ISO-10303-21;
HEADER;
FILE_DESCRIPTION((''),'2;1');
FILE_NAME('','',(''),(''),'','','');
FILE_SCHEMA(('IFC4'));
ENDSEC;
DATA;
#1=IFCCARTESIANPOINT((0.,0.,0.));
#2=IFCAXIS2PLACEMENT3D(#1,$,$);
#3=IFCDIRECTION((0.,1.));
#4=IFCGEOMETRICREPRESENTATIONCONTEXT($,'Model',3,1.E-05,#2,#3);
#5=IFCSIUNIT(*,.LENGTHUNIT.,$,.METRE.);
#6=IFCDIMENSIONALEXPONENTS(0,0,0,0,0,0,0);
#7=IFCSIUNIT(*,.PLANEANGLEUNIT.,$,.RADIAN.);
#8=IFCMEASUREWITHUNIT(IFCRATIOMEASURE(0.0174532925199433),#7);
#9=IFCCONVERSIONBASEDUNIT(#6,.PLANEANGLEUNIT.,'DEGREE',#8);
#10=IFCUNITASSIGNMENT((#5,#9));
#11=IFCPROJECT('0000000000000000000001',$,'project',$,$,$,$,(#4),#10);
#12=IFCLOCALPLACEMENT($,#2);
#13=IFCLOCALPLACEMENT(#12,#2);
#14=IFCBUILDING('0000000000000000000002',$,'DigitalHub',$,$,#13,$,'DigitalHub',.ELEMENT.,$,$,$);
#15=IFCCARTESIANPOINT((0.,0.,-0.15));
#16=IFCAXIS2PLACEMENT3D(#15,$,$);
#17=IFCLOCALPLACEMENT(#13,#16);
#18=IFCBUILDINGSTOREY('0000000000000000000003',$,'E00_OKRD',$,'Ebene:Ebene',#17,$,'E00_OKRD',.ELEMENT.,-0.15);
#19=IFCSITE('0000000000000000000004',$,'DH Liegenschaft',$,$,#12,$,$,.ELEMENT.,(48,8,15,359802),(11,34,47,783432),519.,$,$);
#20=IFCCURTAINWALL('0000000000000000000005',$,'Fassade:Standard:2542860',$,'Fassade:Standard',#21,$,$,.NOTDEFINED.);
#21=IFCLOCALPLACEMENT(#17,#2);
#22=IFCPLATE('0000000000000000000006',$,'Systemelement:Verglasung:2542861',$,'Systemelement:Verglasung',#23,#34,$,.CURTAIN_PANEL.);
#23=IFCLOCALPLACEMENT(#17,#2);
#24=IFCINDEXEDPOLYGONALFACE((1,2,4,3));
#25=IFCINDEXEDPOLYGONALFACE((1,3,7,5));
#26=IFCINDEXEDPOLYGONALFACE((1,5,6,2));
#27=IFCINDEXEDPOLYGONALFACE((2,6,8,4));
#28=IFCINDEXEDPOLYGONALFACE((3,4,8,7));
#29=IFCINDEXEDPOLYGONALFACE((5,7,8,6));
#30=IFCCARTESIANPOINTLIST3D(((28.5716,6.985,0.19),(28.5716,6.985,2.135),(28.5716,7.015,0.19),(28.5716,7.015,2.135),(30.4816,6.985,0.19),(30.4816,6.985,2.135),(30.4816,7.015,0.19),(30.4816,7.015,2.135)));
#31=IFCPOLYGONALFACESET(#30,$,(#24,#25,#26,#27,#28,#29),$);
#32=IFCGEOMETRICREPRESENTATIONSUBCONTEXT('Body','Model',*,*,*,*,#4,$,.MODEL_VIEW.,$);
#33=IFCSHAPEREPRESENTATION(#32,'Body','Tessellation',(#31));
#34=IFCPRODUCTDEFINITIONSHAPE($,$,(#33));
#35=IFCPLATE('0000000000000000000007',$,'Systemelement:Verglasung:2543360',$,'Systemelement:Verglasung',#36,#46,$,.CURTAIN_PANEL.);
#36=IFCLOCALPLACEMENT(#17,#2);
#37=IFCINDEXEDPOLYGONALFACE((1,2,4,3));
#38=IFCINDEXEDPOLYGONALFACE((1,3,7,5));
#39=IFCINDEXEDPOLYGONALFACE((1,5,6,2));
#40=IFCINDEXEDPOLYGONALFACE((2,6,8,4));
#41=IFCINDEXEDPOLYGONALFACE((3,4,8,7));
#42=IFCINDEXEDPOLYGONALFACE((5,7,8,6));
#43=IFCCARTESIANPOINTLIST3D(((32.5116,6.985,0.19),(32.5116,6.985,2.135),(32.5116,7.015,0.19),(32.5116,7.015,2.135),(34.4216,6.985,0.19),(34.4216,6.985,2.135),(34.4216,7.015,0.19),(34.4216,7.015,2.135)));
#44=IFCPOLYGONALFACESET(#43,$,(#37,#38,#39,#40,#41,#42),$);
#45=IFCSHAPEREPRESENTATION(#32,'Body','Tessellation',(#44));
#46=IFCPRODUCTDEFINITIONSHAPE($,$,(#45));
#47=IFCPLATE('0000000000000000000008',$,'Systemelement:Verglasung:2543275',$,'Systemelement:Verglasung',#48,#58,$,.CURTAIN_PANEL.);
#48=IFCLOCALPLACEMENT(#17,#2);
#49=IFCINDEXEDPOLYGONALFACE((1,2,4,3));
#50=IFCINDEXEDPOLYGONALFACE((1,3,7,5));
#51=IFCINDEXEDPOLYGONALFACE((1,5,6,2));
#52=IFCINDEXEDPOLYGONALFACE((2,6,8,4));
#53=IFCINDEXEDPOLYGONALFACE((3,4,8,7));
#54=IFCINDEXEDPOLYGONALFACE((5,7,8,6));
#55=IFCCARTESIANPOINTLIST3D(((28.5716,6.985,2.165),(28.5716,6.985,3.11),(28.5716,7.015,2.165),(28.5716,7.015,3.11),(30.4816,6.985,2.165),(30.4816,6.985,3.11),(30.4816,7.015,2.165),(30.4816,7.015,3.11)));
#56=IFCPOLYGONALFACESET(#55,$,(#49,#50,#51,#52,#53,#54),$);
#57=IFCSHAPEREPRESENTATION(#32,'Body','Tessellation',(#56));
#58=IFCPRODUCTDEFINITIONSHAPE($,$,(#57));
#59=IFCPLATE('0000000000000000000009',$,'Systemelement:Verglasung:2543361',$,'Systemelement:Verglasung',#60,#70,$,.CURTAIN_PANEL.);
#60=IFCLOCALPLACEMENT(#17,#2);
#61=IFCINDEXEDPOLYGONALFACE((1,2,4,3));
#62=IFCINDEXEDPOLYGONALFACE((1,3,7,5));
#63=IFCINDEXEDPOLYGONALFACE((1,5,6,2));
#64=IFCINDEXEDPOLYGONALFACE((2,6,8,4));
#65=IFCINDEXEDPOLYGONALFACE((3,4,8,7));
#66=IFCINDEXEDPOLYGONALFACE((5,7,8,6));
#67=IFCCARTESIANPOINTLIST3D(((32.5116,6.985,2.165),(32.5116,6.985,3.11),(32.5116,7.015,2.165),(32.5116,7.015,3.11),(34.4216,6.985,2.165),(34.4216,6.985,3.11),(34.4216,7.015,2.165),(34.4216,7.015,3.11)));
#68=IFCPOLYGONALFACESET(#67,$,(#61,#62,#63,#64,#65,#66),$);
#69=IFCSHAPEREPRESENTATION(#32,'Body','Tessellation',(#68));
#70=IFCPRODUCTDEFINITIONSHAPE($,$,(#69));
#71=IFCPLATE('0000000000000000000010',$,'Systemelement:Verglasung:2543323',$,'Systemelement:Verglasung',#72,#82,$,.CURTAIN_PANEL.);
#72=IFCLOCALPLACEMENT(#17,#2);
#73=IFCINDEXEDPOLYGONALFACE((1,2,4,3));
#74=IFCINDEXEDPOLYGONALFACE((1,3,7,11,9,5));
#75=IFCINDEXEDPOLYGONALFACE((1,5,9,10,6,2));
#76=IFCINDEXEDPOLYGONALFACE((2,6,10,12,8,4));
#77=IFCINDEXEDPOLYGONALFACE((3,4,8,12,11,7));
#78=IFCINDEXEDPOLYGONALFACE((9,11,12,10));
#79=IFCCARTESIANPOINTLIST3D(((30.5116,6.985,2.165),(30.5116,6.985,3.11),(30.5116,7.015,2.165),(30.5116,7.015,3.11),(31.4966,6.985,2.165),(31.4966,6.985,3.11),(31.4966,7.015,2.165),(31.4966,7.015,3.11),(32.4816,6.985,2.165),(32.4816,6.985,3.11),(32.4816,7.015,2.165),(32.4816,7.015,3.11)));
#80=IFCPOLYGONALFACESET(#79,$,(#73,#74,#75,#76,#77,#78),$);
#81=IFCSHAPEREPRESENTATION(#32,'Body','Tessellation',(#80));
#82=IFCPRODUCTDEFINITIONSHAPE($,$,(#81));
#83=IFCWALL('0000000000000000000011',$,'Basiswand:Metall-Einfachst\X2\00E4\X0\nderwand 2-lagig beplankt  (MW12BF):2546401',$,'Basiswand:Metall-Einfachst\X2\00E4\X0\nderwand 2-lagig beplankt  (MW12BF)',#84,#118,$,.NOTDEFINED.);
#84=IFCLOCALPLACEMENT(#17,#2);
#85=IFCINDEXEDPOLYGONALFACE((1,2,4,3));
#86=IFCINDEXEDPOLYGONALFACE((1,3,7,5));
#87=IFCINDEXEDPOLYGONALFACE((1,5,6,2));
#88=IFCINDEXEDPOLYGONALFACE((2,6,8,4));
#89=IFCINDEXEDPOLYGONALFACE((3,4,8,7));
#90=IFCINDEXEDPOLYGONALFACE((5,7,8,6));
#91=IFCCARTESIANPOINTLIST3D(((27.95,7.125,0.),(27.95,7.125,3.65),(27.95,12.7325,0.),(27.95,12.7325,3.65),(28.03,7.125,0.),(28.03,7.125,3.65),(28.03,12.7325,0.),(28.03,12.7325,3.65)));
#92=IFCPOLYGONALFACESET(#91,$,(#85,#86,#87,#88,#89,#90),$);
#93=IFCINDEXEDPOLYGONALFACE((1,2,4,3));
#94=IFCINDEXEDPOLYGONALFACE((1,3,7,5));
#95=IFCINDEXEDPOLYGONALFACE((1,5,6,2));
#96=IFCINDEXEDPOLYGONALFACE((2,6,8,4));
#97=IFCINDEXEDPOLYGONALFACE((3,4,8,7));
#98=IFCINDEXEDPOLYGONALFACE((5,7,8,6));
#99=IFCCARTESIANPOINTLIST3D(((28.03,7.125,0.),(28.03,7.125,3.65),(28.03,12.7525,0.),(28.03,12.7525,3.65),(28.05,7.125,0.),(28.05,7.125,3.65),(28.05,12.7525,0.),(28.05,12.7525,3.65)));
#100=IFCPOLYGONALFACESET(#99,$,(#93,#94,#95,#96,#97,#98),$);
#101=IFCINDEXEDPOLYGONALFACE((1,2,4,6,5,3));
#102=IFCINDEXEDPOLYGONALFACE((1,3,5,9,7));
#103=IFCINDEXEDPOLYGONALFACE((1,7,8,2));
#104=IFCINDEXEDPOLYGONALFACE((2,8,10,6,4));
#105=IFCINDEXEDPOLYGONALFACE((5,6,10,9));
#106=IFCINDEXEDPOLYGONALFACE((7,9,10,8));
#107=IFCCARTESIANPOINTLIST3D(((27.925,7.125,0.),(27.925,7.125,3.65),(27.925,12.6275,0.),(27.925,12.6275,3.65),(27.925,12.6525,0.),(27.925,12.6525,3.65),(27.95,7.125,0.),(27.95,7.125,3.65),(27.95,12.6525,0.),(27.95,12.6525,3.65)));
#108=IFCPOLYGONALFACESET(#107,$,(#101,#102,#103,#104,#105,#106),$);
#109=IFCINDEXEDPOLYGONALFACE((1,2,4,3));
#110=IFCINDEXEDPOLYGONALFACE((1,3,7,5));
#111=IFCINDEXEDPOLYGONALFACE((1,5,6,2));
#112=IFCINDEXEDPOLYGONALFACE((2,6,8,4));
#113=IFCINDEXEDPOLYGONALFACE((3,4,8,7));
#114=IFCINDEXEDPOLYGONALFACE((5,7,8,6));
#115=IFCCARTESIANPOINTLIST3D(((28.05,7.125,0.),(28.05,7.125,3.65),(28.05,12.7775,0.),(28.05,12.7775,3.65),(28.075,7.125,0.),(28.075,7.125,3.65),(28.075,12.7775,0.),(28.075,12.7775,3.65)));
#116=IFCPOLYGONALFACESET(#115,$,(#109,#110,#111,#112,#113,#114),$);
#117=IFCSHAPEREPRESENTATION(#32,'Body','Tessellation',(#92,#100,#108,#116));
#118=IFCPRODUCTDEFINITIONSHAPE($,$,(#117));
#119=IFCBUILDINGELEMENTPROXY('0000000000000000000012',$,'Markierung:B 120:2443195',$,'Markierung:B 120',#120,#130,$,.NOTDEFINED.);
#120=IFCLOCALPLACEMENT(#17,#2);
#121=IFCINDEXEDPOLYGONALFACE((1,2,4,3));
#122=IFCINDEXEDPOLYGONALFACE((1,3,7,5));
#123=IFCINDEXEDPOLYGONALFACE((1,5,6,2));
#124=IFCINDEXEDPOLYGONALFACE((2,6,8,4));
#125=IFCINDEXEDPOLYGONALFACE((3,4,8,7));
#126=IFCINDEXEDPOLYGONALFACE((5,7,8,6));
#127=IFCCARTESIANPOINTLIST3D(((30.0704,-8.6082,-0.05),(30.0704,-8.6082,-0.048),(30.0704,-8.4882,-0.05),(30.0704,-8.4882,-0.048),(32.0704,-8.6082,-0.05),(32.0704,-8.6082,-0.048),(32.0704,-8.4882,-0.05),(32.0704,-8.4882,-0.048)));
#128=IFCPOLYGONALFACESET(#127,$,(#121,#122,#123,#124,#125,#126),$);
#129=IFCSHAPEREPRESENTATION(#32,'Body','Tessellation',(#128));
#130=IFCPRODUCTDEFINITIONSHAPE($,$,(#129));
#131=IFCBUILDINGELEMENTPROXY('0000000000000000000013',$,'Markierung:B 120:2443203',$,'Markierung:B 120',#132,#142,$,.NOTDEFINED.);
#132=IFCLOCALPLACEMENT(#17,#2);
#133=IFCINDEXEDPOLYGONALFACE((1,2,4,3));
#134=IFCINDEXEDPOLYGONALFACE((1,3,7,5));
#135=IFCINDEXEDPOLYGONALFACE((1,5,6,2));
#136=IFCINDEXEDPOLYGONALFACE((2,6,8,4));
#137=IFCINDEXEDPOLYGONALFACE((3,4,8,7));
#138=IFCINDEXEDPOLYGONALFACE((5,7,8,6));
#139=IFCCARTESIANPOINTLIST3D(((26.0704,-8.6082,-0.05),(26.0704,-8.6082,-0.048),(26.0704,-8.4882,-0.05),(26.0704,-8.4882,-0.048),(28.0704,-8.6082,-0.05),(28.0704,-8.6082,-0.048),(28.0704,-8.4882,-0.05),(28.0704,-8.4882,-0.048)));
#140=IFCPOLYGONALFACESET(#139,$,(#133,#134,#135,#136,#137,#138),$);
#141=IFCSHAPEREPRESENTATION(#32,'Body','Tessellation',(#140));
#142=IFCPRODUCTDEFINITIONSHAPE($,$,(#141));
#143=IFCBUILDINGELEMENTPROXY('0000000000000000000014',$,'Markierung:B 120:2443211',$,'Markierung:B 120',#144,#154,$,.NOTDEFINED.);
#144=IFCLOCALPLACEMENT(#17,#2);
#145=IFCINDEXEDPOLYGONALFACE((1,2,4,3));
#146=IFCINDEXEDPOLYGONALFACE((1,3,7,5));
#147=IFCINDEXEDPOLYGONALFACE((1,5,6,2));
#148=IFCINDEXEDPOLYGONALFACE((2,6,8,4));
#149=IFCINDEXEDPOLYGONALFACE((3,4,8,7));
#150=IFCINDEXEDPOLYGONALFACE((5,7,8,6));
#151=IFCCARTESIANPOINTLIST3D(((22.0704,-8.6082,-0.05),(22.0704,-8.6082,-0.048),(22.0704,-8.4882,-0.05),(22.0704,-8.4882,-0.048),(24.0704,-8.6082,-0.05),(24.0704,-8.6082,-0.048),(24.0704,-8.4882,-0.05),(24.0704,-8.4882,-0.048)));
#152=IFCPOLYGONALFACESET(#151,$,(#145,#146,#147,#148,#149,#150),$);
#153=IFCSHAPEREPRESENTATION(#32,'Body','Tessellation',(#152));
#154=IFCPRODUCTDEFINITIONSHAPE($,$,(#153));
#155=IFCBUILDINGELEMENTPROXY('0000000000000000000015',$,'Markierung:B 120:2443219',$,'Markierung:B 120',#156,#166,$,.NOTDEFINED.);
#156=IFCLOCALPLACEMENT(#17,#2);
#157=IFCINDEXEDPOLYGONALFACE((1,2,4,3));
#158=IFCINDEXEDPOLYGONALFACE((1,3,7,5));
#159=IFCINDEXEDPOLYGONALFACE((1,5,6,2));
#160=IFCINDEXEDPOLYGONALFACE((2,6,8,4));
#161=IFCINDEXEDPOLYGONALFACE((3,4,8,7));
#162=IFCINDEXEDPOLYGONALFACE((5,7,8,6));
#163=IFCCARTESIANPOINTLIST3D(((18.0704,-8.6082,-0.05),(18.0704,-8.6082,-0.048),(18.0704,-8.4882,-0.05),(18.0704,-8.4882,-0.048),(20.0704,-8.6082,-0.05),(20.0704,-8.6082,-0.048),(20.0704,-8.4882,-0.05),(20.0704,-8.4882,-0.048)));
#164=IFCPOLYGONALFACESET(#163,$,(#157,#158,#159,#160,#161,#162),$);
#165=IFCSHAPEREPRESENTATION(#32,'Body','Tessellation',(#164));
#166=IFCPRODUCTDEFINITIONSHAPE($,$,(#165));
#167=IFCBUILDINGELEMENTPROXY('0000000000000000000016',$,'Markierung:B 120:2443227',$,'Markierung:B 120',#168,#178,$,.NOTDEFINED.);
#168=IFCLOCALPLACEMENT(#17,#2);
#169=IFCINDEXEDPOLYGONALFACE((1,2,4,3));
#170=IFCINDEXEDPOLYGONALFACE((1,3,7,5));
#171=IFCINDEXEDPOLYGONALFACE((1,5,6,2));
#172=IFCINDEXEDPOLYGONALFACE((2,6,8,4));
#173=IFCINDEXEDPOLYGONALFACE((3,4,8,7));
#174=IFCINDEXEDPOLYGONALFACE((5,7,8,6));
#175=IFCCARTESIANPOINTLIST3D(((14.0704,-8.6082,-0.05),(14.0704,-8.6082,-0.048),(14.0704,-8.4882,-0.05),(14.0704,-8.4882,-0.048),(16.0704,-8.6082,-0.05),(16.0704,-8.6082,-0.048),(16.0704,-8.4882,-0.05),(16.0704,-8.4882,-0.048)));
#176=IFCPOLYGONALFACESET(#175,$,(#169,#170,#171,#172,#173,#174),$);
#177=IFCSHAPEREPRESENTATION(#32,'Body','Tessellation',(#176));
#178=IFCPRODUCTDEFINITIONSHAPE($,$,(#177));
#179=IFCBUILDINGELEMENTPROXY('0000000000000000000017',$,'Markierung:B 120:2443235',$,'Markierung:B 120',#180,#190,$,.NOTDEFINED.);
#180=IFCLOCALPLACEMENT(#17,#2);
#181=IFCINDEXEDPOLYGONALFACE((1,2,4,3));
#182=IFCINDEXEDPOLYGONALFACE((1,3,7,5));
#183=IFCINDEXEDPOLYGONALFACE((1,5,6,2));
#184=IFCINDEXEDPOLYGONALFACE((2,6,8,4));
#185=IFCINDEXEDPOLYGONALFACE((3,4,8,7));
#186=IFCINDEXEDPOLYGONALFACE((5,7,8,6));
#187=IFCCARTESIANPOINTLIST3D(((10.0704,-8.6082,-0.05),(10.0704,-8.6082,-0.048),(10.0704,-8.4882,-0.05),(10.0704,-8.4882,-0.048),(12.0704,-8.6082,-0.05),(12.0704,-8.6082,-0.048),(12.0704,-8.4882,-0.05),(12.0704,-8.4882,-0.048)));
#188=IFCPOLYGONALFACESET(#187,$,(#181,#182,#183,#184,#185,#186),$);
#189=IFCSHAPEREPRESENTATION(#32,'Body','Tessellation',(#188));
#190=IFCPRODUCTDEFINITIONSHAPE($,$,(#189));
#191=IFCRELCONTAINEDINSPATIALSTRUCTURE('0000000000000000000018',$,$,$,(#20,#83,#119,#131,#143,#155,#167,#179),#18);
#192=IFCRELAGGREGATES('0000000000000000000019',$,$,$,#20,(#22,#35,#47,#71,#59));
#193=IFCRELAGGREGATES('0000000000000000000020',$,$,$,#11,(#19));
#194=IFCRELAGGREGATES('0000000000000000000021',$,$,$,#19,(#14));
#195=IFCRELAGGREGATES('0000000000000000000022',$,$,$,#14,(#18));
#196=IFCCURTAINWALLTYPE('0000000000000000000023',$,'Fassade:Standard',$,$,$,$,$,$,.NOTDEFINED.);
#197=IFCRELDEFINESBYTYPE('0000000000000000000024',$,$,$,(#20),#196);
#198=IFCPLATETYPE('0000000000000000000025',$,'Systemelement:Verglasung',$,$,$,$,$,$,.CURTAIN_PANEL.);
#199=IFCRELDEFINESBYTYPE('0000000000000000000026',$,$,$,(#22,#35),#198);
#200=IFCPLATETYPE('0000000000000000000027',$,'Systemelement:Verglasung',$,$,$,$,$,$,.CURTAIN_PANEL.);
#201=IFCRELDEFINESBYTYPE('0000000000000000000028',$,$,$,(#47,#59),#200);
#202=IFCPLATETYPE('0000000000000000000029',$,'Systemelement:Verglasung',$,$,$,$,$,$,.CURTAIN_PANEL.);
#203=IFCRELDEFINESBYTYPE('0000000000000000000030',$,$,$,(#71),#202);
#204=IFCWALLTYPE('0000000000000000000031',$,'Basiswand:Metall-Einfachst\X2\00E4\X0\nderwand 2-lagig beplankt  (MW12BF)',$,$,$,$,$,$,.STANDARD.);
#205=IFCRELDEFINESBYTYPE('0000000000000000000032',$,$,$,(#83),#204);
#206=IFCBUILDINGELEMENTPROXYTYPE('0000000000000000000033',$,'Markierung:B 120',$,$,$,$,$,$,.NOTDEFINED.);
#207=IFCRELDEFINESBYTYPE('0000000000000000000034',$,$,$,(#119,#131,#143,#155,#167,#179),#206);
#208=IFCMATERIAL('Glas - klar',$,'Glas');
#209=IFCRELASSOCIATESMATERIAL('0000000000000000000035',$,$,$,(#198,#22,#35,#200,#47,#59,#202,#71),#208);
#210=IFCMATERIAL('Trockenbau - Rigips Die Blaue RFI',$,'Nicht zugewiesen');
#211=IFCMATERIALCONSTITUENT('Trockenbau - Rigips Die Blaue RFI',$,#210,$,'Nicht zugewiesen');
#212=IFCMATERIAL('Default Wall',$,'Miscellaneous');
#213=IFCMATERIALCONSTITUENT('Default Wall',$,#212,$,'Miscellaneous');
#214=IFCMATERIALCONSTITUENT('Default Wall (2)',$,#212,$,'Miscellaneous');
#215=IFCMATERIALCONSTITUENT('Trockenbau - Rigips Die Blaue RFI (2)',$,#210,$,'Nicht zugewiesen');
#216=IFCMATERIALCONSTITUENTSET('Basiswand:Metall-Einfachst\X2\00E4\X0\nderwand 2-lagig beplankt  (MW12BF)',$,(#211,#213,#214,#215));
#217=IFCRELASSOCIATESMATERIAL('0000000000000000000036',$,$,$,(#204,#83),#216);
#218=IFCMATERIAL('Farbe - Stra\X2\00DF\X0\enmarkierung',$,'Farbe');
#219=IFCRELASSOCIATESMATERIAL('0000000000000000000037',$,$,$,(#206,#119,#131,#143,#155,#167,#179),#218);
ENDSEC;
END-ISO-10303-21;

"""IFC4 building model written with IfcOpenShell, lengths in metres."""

from ifc_helpers import new_model, entity, si_unit, converted_unit, direction, frame, origin, place, context, subcontext, project, spatial, indexed_curve, outline, extrude, source, transform, mapped, material, constituent, constituent_set, type_object, type_shapes, element, aggregate, save


model = new_model("IFC4")

# Units and contexts
model_context = context("Model", 3, precision=1e-05, world=origin(), true_north=direction((0.0, 1.0)))
body_context = subcontext(model_context, "Body", "Model", "MODEL_VIEW")
ifc_project = project(units=[si_unit("LENGTHUNIT", "METRE"), converted_unit("PLANEANGLEUNIT", "DEGREE", entity("IfcRatioMeasure", 0.0174532925199433), si_unit("PLANEANGLEUNIT", "RADIAN"), dimensions=[0, 0, 0, 0, 0, 0, 0])], contexts=[model_context])

# Site, building, storey
site_placement = place(None, frame((0.0, 0.0, 0.0)))
site = spatial("IfcSite", under=ifc_project, at=site_placement, Name="DH Liegenschaft", CompositionType="ELEMENT", RefLatitude=(48, 8, 15, 359802), RefLongitude=(11, 34, 47, 783432), RefElevation=519.0)
building_placement = place(site_placement, origin())
building = spatial("IfcBuilding", under=site, at=building_placement, Name="DigitalHub", LongName="DigitalHub", CompositionType="ELEMENT")
storey_placement = place(building_placement, frame((0.0, 0.0, -0.15)))
storey = spatial("IfcBuildingStorey", under=building, at=storey_placement, Name="E00_OKRD", ObjectType="Ebene:Ebene", LongName="E00_OKRD", CompositionType="ELEMENT", Elevation=-0.15)

# Curtain wall, plates
curtain_wall_type = type_object("IfcCurtainWallType", Name="Fassade:Standard", PredefinedType="NOTDEFINED")
curtain_wall_placement = place(storey_placement, frame((0.0, 0.0, 0.15)))
curtain_wall = element("IfcCurtainWall", 1, at=curtain_wall_placement, inside=storey, type_object=curtain_wall_type, Name="Fassade:Standard:2542860", ObjectType="Fassade:Standard", PredefinedType="NOTDEFINED")
ifc_material_1 = material(Name="Glas - klar", Category="Glas")
plate_type_1 = type_object("IfcPlateType", Name="Systemelement:Verglasung", PredefinedType="CURTAIN_PANEL", material=ifc_material_1)
shared_shape_1 = source(origin(), body_context, "Body", "SweptSolid", [
    extrude(outline(indexed_curve([(-0.015, -0.955), (0.015, -0.955), (0.015, 0.955), (-0.015, 0.955), (-0.015, -0.955)], self_intersect=False)), frame((0.0, 0.0, 0.0), z_axis=(0.0, 0.0, 1.0), x_axis=(0.0, 1.0, 0.0)), (0.0, 0.0, 1.0), 1.945),
])
type_shapes(plate_type_1, [shared_shape_1])
plate_1_placement = place(curtain_wall_placement, frame((29.5266, 7.0, 0.04)))
plate_1 = element("IfcPlate", 2, at=plate_1_placement, type_object=plate_type_1, material=ifc_material_1, Name="Systemelement:Verglasung:2542861", ObjectType="Systemelement:Verglasung", PredefinedType="CURTAIN_PANEL", context=body_context, shape_type="MappedRepresentation", body=[
    mapped(shared_shape_1, transform((0.0, 0.0, 0.0), scale=1.0)),
])
plate_2_placement = place(curtain_wall_placement, frame((33.4666, 7.0, 0.04)))
plate_2 = element("IfcPlate", 3, at=plate_2_placement, type_object=plate_type_1, material=ifc_material_1, Name="Systemelement:Verglasung:2543360", ObjectType="Systemelement:Verglasung", PredefinedType="CURTAIN_PANEL", context=body_context, shape_type="MappedRepresentation", body=[
    mapped(shared_shape_1, transform((0.0, 0.0, 0.0), scale=1.0)),
])
plate_type_2 = type_object("IfcPlateType", Name="Systemelement:Verglasung", PredefinedType="CURTAIN_PANEL", material=ifc_material_1)
shared_shape_2 = source(origin(), body_context, "Body", "SweptSolid", [
    extrude(outline(indexed_curve([(-0.015, -0.955), (0.015, -0.955), (0.015, 0.955), (-0.015, 0.955), (-0.015, -0.955)], self_intersect=False)), frame((0.0, 0.0, 0.0), z_axis=(0.0, 0.0, 1.0), x_axis=(0.0, 1.0, 0.0)), (0.0, 0.0, 1.0), 0.945),
])
type_shapes(plate_type_2, [shared_shape_2])
plate_3_placement = place(curtain_wall_placement, frame((29.5266, 7.0, 2.015)))
plate_3 = element("IfcPlate", 4, at=plate_3_placement, type_object=plate_type_2, material=ifc_material_1, Name="Systemelement:Verglasung:2543275", ObjectType="Systemelement:Verglasung", PredefinedType="CURTAIN_PANEL", context=body_context, shape_type="MappedRepresentation", body=[
    mapped(shared_shape_2, transform((0.0, 0.0, 0.0), scale=1.0)),
])
plate_4_placement = place(curtain_wall_placement, frame((33.4666, 7.0, 2.015)))
plate_4 = element("IfcPlate", 5, at=plate_4_placement, type_object=plate_type_2, material=ifc_material_1, Name="Systemelement:Verglasung:2543361", ObjectType="Systemelement:Verglasung", PredefinedType="CURTAIN_PANEL", context=body_context, shape_type="MappedRepresentation", body=[
    mapped(shared_shape_2, transform((0.0, 0.0, 0.0), scale=1.0)),
])
plate_type_3 = type_object("IfcPlateType", Name="Systemelement:Verglasung", PredefinedType="CURTAIN_PANEL", material=ifc_material_1)
shared_shape_3 = source(origin(), body_context, "Body", "SweptSolid", [
    extrude(outline(indexed_curve([(-0.4725, -0.985), (0.4725, -0.985), (0.4725, 0.0), (0.4725, 0.985), (-0.4725, 0.985), (-0.4725, 0.0), (-0.4725, -0.985)], self_intersect=False)), frame((0.0, -0.015, 0.4725), z_axis=(0.0, 1.0, 0.0), x_axis=(0.0, 0.0, 1.0)), (0.0, 0.0, 1.0), 0.03),
])
type_shapes(plate_type_3, [shared_shape_3])
plate_5_placement = place(curtain_wall_placement, frame((31.4966, 7.0, 2.015)))
plate_5 = element("IfcPlate", 6, at=plate_5_placement, type_object=plate_type_3, material=ifc_material_1, Name="Systemelement:Verglasung:2543323", ObjectType="Systemelement:Verglasung", PredefinedType="CURTAIN_PANEL", context=body_context, shape_type="MappedRepresentation", body=[
    mapped(shared_shape_3, transform((0.0, 0.0, 0.0), scale=1.0)),
])
aggregate(curtain_wall, [plate_1, plate_2, plate_3, plate_5, plate_4])

# Wall
ifc_material_2 = material(Name="Trockenbau - Rigips Die Blaue RFI", Category="Nicht zugewiesen")
ifc_constituent_1 = constituent(ifc_material_2, Name="Trockenbau - Rigips Die Blaue RFI", Category="Nicht zugewiesen")
ifc_material_3 = material(Name="Default Wall", Category="Miscellaneous")
ifc_constituent_2 = constituent(ifc_material_3, Name="Default Wall", Category="Miscellaneous")
ifc_constituent_3 = constituent(ifc_material_3, Name="Default Wall (2)", Category="Miscellaneous")
ifc_constituent_4 = constituent(ifc_material_2, Name="Trockenbau - Rigips Die Blaue RFI (2)", Category="Nicht zugewiesen")
ifc_constituent_set_1 = constituent_set(constituents=[ifc_constituent_1, ifc_constituent_2, ifc_constituent_3, ifc_constituent_4], Name="Basiswand:Metall-Einfachständerwand 2-lagig beplankt  (MW12BF)")
wall_type = type_object("IfcWallType", Name="Basiswand:Metall-Einfachständerwand 2-lagig beplankt  (MW12BF)", PredefinedType="STANDARD", material=ifc_constituent_set_1)
wall_1_placement = place(storey_placement, frame((28.0, 7.125, 0.0), z_axis=(0.0, 0.0, 1.0), x_axis=(0.0, 1.0, 0.0)))
element("IfcWall", 7, at=wall_1_placement, inside=storey, type_object=wall_type, material=ifc_constituent_set_1, Name="Basiswand:Metall-Einfachständerwand 2-lagig beplankt  (MW12BF):2546401", ObjectType="Basiswand:Metall-Einfachständerwand 2-lagig beplankt  (MW12BF)", PredefinedType="NOTDEFINED", context=body_context, shape_type="SweptSolid", body=[
    extrude(outline(indexed_curve([(-2.8038, -0.04), (2.8038, -0.04), (2.8038, 0.04), (-2.8038, 0.04), (-2.8038, -0.04)], self_intersect=False)), frame((2.8038, 0.01, 0.0)), (0.0, 0.0, 1.0), 3.65),
    extrude(outline(indexed_curve([(-2.8138, -0.01), (2.8138, -0.01), (2.8138, 0.01), (-2.8138, 0.01), (-2.8138, -0.01)], self_intersect=False)), frame((2.8138, -0.04, 0.0)), (0.0, 0.0, 1.0), 3.65),
    extrude(outline(indexed_curve([(-2.191, -0.01), (3.3115, -0.01), (3.3115, 0.015), (-2.216, 0.015), (-2.216, -0.01), (-2.191, -0.01)], self_intersect=False)), frame((3.3115, 0.065, 0.0), z_axis=(0.0, 0.0, 1.0), x_axis=(-1.0, 0.0, 0.0)), (0.0, 0.0, 1.0), 3.65),
    extrude(outline(indexed_curve([(-0.0125, -2.8263), (0.0125, -2.8263), (0.0125, 2.8263), (-0.0125, 2.8263), (-0.0125, -2.8263)], self_intersect=False)), frame((2.8263, -0.0625, 0.0), z_axis=(0.0, 0.0, 1.0), x_axis=(0.0, 1.0, 0.0)), (0.0, 0.0, 1.0), 3.65),
])

# Building element proxies
ifc_material_4 = material(Name="Farbe - Straßenmarkierung", Category="Farbe")
building_element_proxy_type = type_object("IfcBuildingElementProxyType", Name="Markierung:B 120", PredefinedType="NOTDEFINED", material=ifc_material_4)
shared_shape_4 = source(origin(), body_context, "Body", "SweptSolid", [
    extrude(outline(indexed_curve([(-0.06, -1.0), (0.06, -1.0), (0.06, 1.0), (-0.06, 1.0), (-0.06, -1.0)], self_intersect=False)), frame((0.06, 1.0, 0.0), z_axis=(0.0, 0.0, 1.0), x_axis=(-1.0, 0.0, 0.0)), (0.0, 0.0, 1.0), 0.002),
])
type_shapes(building_element_proxy_type, [shared_shape_4])
for number, where, z_axis, x_axis, name in (
    (8, (32.0704, -8.6082, -0.05), (0.0, 0.0, 1.0), (0.0, 1.0, 0.0), "Markierung:B 120:2443195"),
    (9, (28.0704, -8.6082, -0.05), (0.0, 0.0, 1.0), (0.0, 1.0, 0.0), "Markierung:B 120:2443203"),
    (10, (24.0704, -8.6082, -0.05), (0.0, 0.0, 1.0), (0.0, 1.0, 0.0), "Markierung:B 120:2443211"),
    (11, (20.0704, -8.6082, -0.05), (0.0, 0.0, 1.0), (0.0, 1.0, 0.0), "Markierung:B 120:2443219"),
    (12, (16.0704, -8.6082, -0.05), (0.0, 0.0, 1.0), (0.0, 1.0, 0.0), "Markierung:B 120:2443227"),
    (13, (12.0704, -8.6082, -0.05), (0.0, 0.0, 1.0), (0.0, 1.0, 0.0), "Markierung:B 120:2443235"),
):
    element("IfcBuildingElementProxy", number, at=place(storey_placement, frame(where, z_axis=z_axis, x_axis=x_axis)), inside=storey, type_object=building_element_proxy_type, material=ifc_material_4, Name=name, ObjectType="Markierung:B 120", PredefinedType="NOTDEFINED", context=body_context, shape_type="MappedRepresentation", body=[
        mapped(shared_shape_4, transform((0.0, 0.0, 0.0), scale=1.0)),
    ])

save(model, "model.ifc")
